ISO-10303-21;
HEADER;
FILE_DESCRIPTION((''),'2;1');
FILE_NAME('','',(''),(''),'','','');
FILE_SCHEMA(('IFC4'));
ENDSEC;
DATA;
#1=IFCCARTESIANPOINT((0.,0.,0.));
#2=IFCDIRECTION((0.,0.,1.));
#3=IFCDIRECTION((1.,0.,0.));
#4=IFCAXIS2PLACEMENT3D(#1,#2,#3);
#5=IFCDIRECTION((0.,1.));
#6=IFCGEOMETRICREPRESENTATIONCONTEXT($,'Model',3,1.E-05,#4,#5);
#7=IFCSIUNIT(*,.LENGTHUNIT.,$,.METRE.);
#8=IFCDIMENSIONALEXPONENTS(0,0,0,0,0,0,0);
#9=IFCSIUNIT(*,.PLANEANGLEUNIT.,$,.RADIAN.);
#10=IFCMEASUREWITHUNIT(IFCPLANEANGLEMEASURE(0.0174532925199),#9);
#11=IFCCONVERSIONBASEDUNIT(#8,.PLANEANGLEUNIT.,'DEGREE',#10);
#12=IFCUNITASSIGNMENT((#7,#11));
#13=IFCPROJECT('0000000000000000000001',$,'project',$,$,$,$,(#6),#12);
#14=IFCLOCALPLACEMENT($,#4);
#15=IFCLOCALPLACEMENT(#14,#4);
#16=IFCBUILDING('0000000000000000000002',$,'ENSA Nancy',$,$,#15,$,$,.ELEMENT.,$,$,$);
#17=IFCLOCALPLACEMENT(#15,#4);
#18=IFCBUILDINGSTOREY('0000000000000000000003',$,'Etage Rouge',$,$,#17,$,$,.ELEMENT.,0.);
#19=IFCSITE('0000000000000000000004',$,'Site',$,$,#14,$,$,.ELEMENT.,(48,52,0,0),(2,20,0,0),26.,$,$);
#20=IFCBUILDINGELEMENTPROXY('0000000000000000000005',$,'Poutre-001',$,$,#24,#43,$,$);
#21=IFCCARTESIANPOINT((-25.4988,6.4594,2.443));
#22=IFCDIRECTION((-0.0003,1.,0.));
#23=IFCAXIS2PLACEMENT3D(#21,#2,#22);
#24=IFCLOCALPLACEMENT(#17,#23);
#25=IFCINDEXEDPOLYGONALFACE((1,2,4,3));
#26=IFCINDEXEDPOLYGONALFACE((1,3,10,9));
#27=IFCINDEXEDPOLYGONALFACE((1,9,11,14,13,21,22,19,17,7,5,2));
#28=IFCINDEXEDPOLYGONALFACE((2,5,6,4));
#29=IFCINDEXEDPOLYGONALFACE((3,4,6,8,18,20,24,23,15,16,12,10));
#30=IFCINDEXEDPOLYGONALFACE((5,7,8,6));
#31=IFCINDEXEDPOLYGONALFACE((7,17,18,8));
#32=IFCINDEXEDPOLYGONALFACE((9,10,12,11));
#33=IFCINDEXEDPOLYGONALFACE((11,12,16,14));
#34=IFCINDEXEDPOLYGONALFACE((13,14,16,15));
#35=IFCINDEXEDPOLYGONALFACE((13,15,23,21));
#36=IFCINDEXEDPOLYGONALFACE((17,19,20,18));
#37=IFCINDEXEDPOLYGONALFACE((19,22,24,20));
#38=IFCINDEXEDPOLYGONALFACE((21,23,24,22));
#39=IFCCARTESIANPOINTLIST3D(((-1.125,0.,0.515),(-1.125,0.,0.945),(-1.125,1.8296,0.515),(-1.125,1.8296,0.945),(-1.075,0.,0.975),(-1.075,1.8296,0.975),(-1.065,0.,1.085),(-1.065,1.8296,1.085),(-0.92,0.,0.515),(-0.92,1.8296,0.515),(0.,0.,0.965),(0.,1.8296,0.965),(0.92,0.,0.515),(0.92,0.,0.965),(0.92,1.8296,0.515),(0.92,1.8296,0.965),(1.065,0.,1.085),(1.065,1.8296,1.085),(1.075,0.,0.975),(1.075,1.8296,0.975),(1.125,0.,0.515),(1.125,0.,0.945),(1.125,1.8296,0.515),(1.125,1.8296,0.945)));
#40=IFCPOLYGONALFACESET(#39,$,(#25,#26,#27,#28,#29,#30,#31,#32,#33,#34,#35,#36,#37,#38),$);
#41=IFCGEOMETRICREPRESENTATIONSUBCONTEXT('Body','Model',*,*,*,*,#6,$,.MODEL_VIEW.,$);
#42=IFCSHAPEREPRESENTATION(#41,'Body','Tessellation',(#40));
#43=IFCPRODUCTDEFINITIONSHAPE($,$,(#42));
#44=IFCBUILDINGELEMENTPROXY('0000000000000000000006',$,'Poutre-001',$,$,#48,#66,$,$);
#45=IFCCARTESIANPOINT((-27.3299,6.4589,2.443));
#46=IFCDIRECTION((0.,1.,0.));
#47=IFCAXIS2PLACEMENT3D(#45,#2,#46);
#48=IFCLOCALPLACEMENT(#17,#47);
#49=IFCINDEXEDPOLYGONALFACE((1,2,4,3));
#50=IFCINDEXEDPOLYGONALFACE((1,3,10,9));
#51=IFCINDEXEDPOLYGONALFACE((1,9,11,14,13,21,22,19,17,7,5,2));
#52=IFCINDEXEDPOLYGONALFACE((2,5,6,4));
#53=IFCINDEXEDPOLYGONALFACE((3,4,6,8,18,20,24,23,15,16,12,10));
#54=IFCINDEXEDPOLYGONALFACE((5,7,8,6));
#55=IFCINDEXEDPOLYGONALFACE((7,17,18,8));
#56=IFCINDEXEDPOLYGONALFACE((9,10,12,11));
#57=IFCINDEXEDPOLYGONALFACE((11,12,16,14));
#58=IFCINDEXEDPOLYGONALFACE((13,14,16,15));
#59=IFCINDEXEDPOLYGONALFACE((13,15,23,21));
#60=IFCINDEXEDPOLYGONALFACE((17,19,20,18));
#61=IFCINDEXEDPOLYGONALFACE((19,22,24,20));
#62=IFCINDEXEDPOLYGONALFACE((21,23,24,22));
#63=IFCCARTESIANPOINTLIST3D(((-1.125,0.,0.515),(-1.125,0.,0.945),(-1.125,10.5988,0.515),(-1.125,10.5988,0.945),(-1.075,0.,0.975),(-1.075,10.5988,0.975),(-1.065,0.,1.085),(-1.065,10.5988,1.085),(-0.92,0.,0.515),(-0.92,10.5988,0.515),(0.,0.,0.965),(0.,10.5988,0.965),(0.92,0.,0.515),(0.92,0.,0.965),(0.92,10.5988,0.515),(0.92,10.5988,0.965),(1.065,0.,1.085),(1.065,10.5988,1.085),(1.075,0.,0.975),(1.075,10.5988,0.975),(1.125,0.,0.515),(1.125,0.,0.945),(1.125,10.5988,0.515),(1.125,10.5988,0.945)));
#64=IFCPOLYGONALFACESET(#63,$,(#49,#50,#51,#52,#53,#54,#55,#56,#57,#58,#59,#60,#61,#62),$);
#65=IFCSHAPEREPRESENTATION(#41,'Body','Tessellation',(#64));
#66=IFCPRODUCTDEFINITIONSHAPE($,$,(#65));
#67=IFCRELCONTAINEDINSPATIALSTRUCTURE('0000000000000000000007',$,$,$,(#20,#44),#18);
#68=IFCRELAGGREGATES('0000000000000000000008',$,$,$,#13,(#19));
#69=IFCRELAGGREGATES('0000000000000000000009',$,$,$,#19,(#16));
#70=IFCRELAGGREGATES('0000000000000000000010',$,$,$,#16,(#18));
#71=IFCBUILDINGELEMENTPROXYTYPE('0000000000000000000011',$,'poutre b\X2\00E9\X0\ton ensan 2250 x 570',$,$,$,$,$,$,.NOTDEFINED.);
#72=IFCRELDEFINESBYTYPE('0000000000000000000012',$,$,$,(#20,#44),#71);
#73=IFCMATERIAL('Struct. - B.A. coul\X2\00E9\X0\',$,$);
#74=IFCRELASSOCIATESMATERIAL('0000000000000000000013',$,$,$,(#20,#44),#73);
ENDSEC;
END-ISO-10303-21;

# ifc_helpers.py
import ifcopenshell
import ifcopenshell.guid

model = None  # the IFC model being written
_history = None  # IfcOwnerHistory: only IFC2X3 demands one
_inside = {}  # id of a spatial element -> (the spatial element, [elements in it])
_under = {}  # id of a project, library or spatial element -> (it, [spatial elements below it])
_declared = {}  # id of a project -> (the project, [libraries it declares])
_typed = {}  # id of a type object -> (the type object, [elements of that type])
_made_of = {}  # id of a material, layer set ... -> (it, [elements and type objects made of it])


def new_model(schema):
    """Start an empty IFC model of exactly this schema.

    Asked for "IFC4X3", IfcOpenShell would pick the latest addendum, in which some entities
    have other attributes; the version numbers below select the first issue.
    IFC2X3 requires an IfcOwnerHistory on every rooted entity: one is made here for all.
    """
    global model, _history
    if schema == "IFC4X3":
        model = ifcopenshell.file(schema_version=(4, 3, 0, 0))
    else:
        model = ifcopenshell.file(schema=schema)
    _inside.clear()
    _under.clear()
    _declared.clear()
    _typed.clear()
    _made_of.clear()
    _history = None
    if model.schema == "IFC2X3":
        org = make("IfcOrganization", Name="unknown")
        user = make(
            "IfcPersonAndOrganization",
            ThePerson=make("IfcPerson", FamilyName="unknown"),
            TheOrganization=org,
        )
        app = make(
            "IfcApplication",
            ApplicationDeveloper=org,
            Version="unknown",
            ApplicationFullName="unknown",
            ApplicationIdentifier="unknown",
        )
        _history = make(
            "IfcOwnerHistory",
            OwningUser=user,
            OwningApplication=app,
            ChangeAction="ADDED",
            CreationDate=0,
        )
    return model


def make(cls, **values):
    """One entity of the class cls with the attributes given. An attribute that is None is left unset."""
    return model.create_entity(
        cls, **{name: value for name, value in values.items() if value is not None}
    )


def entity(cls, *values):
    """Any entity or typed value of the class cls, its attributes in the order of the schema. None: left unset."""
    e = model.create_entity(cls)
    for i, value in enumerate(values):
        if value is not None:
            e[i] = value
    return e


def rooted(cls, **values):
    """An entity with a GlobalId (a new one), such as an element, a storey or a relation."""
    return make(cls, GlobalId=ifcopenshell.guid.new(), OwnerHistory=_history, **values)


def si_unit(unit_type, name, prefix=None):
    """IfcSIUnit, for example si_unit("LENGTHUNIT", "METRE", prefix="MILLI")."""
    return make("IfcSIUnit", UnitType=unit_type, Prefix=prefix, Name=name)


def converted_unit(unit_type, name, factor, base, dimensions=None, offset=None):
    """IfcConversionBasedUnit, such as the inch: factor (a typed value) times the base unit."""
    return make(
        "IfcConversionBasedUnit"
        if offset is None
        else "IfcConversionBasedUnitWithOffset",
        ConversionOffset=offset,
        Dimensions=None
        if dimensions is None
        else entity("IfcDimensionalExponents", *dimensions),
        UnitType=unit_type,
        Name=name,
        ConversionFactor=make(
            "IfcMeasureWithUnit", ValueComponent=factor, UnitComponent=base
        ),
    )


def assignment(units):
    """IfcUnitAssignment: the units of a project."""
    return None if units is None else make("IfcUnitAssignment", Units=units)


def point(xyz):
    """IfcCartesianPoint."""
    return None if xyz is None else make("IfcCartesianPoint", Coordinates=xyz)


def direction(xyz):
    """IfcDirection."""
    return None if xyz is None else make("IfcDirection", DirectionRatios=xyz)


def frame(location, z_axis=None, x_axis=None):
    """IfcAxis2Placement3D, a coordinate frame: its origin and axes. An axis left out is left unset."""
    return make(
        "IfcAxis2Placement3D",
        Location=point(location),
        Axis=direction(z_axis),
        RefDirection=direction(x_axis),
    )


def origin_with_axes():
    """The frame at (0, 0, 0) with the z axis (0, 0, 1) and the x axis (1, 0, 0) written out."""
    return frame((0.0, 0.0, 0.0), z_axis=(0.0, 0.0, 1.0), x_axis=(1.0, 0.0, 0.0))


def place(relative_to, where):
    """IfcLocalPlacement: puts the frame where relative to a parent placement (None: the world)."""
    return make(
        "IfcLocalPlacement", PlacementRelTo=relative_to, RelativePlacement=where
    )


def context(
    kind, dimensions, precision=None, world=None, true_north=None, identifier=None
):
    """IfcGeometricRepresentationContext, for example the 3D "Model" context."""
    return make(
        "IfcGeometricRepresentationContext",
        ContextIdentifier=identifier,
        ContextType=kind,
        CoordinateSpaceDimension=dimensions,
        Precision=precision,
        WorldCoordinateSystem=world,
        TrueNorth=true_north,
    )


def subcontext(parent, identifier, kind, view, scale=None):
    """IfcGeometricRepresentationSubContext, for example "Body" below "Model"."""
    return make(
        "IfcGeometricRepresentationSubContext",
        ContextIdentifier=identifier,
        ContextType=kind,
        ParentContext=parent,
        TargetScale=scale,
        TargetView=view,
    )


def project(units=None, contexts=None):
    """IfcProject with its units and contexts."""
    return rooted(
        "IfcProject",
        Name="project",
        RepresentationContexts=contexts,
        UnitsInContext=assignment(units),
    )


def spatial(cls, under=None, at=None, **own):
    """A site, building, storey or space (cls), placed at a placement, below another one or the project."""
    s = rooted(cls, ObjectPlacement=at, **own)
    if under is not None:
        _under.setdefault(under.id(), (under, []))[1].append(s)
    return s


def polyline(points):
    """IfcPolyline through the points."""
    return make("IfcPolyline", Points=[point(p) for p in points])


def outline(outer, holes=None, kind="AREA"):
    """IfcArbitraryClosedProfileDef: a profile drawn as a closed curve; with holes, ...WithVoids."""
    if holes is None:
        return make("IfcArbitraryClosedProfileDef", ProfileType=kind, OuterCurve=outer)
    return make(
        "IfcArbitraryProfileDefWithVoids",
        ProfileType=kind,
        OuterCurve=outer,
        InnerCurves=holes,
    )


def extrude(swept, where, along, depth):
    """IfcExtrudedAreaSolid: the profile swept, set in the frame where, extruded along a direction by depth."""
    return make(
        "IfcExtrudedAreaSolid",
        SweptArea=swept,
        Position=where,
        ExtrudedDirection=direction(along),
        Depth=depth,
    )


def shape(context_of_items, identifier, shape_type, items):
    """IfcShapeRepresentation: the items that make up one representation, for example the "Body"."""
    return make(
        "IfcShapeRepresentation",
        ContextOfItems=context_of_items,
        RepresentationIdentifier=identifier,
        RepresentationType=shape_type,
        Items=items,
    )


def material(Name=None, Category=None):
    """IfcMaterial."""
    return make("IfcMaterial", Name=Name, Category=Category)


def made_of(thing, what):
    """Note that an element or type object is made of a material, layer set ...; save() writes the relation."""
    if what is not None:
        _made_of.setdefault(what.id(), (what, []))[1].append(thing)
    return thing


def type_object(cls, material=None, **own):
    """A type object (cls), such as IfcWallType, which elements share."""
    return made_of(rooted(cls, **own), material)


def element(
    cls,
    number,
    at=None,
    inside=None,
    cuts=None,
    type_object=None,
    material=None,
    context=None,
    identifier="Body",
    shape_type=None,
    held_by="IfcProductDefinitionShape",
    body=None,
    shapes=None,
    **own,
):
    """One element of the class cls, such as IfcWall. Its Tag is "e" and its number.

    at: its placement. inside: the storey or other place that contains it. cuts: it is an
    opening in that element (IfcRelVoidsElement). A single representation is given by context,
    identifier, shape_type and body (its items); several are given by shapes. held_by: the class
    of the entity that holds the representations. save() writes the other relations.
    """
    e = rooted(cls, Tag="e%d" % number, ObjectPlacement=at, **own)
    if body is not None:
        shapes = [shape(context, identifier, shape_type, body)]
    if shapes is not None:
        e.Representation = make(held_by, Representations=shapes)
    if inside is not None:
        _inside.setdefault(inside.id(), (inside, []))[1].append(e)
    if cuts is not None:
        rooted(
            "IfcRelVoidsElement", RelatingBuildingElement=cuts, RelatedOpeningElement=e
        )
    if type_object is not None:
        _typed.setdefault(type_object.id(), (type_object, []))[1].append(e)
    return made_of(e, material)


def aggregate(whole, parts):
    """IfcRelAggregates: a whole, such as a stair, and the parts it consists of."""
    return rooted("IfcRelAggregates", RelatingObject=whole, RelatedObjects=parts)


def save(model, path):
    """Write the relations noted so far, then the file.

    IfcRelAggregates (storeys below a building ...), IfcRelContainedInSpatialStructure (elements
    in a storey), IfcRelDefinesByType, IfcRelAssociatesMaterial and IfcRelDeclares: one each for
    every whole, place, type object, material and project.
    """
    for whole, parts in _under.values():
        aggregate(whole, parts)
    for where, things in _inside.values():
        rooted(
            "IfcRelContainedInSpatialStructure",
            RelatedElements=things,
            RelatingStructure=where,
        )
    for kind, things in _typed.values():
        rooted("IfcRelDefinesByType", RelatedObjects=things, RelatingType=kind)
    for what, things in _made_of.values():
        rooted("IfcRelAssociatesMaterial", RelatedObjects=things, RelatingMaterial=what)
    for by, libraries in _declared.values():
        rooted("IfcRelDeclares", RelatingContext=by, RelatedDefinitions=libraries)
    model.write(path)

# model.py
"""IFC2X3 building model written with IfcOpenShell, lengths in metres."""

from ifc_helpers import new_model, entity, si_unit, converted_unit, direction, frame, origin_with_axes, place, context, subcontext, project, spatial, polyline, outline, extrude, material, type_object, element, save


model = new_model("IFC2X3")

# Units and contexts
model_context = context("Model", 3, precision=1e-05, world=origin_with_axes(), true_north=direction((0.0, 1.0)))
body_context = subcontext(model_context, "Body", "Model", "MODEL_VIEW")
ifc_project = project(units=[si_unit("LENGTHUNIT", "METRE"), converted_unit("PLANEANGLEUNIT", "DEGREE", entity("IfcPlaneAngleMeasure", 0.0174532925199), si_unit("PLANEANGLEUNIT", "RADIAN"), dimensions=[0, 0, 0, 0, 0, 0, 0])], contexts=[model_context])

# Site, building, storey
site_placement = place(None, origin_with_axes())
site = spatial("IfcSite", under=ifc_project, at=site_placement, Name="Site", CompositionType="ELEMENT", RefLatitude=(48, 52, 0, 0), RefLongitude=(2, 20, 0, 0), RefElevation=26.0)
building_placement = place(site_placement, origin_with_axes())
building = spatial("IfcBuilding", under=site, at=building_placement, Name="ENSA Nancy", CompositionType="ELEMENT")
storey_placement = place(building_placement, origin_with_axes())
storey = spatial("IfcBuildingStorey", under=building, at=storey_placement, Name="Etage Rouge", CompositionType="ELEMENT", Elevation=0.0)

# Building element proxies
ifc_material_1 = material(Name="Struct. - B.A. coulé")
building_element_proxy_type_1 = type_object("IfcBuildingElementProxyType", Name="poutre béton ensan 2250 x 570", PredefinedType="NOTDEFINED")
for number, where, z_axis, x_axis, name in (
    (1, (-25.4988, 6.4594, 2.443), (0.0, 0.0, 1.0), (-0.0003, 1.0, 0.0), "Poutre-001"),
):
    element("IfcBuildingElementProxy", number, at=place(storey_placement, frame(where, z_axis=z_axis, x_axis=x_axis)), inside=storey, type_object=building_element_proxy_type_1, material=ifc_material_1, Name=name, context=body_context, shape_type="SweptSolid", body=[
        extrude(outline(polyline([(-1.065, 1.085), (-1.075, 0.975), (-1.125, 0.945), (-1.125, 0.515), (-0.92, 0.515), (0.0, 0.965), (0.92, 0.965), (0.92, 0.515), (1.125, 0.515), (1.125, 0.945), (1.075, 0.975), (1.065, 1.085), (-1.065, 1.085)])), frame((0.0, 1.8296, 0.0), z_axis=(0.0, -1.0, 0.0), x_axis=(1.0, 0.0, 0.0)), (0.0, 0.0, 1.0), 1.8296),
    ])
proxy_1_placement = place(storey_placement, frame((-27.3299, 6.4589, 2.443), z_axis=(0.0, 0.0, 1.0), x_axis=(0.0, 1.0, 0.0)))
element("IfcBuildingElementProxy", 2, at=proxy_1_placement, inside=storey, type_object=building_element_proxy_type_1, material=ifc_material_1, Name="Poutre-001", context=body_context, shape_type="SweptSolid", body=[
    extrude(outline(polyline([(-1.065, 1.085), (-1.075, 0.975), (-1.125, 0.945), (-1.125, 0.515), (-0.92, 0.515), (0.0, 0.965), (0.92, 0.965), (0.92, 0.515), (1.125, 0.515), (1.125, 0.945), (1.075, 0.975), (1.065, 1.085), (-1.065, 1.085)])), frame((0.0, 10.5988, 0.0), z_axis=(0.0, -1.0, 0.0), x_axis=(1.0, 0.0, 0.0)), (0.0, 0.0, 1.0), 10.5988),
])

save(model, "model.ifc")
